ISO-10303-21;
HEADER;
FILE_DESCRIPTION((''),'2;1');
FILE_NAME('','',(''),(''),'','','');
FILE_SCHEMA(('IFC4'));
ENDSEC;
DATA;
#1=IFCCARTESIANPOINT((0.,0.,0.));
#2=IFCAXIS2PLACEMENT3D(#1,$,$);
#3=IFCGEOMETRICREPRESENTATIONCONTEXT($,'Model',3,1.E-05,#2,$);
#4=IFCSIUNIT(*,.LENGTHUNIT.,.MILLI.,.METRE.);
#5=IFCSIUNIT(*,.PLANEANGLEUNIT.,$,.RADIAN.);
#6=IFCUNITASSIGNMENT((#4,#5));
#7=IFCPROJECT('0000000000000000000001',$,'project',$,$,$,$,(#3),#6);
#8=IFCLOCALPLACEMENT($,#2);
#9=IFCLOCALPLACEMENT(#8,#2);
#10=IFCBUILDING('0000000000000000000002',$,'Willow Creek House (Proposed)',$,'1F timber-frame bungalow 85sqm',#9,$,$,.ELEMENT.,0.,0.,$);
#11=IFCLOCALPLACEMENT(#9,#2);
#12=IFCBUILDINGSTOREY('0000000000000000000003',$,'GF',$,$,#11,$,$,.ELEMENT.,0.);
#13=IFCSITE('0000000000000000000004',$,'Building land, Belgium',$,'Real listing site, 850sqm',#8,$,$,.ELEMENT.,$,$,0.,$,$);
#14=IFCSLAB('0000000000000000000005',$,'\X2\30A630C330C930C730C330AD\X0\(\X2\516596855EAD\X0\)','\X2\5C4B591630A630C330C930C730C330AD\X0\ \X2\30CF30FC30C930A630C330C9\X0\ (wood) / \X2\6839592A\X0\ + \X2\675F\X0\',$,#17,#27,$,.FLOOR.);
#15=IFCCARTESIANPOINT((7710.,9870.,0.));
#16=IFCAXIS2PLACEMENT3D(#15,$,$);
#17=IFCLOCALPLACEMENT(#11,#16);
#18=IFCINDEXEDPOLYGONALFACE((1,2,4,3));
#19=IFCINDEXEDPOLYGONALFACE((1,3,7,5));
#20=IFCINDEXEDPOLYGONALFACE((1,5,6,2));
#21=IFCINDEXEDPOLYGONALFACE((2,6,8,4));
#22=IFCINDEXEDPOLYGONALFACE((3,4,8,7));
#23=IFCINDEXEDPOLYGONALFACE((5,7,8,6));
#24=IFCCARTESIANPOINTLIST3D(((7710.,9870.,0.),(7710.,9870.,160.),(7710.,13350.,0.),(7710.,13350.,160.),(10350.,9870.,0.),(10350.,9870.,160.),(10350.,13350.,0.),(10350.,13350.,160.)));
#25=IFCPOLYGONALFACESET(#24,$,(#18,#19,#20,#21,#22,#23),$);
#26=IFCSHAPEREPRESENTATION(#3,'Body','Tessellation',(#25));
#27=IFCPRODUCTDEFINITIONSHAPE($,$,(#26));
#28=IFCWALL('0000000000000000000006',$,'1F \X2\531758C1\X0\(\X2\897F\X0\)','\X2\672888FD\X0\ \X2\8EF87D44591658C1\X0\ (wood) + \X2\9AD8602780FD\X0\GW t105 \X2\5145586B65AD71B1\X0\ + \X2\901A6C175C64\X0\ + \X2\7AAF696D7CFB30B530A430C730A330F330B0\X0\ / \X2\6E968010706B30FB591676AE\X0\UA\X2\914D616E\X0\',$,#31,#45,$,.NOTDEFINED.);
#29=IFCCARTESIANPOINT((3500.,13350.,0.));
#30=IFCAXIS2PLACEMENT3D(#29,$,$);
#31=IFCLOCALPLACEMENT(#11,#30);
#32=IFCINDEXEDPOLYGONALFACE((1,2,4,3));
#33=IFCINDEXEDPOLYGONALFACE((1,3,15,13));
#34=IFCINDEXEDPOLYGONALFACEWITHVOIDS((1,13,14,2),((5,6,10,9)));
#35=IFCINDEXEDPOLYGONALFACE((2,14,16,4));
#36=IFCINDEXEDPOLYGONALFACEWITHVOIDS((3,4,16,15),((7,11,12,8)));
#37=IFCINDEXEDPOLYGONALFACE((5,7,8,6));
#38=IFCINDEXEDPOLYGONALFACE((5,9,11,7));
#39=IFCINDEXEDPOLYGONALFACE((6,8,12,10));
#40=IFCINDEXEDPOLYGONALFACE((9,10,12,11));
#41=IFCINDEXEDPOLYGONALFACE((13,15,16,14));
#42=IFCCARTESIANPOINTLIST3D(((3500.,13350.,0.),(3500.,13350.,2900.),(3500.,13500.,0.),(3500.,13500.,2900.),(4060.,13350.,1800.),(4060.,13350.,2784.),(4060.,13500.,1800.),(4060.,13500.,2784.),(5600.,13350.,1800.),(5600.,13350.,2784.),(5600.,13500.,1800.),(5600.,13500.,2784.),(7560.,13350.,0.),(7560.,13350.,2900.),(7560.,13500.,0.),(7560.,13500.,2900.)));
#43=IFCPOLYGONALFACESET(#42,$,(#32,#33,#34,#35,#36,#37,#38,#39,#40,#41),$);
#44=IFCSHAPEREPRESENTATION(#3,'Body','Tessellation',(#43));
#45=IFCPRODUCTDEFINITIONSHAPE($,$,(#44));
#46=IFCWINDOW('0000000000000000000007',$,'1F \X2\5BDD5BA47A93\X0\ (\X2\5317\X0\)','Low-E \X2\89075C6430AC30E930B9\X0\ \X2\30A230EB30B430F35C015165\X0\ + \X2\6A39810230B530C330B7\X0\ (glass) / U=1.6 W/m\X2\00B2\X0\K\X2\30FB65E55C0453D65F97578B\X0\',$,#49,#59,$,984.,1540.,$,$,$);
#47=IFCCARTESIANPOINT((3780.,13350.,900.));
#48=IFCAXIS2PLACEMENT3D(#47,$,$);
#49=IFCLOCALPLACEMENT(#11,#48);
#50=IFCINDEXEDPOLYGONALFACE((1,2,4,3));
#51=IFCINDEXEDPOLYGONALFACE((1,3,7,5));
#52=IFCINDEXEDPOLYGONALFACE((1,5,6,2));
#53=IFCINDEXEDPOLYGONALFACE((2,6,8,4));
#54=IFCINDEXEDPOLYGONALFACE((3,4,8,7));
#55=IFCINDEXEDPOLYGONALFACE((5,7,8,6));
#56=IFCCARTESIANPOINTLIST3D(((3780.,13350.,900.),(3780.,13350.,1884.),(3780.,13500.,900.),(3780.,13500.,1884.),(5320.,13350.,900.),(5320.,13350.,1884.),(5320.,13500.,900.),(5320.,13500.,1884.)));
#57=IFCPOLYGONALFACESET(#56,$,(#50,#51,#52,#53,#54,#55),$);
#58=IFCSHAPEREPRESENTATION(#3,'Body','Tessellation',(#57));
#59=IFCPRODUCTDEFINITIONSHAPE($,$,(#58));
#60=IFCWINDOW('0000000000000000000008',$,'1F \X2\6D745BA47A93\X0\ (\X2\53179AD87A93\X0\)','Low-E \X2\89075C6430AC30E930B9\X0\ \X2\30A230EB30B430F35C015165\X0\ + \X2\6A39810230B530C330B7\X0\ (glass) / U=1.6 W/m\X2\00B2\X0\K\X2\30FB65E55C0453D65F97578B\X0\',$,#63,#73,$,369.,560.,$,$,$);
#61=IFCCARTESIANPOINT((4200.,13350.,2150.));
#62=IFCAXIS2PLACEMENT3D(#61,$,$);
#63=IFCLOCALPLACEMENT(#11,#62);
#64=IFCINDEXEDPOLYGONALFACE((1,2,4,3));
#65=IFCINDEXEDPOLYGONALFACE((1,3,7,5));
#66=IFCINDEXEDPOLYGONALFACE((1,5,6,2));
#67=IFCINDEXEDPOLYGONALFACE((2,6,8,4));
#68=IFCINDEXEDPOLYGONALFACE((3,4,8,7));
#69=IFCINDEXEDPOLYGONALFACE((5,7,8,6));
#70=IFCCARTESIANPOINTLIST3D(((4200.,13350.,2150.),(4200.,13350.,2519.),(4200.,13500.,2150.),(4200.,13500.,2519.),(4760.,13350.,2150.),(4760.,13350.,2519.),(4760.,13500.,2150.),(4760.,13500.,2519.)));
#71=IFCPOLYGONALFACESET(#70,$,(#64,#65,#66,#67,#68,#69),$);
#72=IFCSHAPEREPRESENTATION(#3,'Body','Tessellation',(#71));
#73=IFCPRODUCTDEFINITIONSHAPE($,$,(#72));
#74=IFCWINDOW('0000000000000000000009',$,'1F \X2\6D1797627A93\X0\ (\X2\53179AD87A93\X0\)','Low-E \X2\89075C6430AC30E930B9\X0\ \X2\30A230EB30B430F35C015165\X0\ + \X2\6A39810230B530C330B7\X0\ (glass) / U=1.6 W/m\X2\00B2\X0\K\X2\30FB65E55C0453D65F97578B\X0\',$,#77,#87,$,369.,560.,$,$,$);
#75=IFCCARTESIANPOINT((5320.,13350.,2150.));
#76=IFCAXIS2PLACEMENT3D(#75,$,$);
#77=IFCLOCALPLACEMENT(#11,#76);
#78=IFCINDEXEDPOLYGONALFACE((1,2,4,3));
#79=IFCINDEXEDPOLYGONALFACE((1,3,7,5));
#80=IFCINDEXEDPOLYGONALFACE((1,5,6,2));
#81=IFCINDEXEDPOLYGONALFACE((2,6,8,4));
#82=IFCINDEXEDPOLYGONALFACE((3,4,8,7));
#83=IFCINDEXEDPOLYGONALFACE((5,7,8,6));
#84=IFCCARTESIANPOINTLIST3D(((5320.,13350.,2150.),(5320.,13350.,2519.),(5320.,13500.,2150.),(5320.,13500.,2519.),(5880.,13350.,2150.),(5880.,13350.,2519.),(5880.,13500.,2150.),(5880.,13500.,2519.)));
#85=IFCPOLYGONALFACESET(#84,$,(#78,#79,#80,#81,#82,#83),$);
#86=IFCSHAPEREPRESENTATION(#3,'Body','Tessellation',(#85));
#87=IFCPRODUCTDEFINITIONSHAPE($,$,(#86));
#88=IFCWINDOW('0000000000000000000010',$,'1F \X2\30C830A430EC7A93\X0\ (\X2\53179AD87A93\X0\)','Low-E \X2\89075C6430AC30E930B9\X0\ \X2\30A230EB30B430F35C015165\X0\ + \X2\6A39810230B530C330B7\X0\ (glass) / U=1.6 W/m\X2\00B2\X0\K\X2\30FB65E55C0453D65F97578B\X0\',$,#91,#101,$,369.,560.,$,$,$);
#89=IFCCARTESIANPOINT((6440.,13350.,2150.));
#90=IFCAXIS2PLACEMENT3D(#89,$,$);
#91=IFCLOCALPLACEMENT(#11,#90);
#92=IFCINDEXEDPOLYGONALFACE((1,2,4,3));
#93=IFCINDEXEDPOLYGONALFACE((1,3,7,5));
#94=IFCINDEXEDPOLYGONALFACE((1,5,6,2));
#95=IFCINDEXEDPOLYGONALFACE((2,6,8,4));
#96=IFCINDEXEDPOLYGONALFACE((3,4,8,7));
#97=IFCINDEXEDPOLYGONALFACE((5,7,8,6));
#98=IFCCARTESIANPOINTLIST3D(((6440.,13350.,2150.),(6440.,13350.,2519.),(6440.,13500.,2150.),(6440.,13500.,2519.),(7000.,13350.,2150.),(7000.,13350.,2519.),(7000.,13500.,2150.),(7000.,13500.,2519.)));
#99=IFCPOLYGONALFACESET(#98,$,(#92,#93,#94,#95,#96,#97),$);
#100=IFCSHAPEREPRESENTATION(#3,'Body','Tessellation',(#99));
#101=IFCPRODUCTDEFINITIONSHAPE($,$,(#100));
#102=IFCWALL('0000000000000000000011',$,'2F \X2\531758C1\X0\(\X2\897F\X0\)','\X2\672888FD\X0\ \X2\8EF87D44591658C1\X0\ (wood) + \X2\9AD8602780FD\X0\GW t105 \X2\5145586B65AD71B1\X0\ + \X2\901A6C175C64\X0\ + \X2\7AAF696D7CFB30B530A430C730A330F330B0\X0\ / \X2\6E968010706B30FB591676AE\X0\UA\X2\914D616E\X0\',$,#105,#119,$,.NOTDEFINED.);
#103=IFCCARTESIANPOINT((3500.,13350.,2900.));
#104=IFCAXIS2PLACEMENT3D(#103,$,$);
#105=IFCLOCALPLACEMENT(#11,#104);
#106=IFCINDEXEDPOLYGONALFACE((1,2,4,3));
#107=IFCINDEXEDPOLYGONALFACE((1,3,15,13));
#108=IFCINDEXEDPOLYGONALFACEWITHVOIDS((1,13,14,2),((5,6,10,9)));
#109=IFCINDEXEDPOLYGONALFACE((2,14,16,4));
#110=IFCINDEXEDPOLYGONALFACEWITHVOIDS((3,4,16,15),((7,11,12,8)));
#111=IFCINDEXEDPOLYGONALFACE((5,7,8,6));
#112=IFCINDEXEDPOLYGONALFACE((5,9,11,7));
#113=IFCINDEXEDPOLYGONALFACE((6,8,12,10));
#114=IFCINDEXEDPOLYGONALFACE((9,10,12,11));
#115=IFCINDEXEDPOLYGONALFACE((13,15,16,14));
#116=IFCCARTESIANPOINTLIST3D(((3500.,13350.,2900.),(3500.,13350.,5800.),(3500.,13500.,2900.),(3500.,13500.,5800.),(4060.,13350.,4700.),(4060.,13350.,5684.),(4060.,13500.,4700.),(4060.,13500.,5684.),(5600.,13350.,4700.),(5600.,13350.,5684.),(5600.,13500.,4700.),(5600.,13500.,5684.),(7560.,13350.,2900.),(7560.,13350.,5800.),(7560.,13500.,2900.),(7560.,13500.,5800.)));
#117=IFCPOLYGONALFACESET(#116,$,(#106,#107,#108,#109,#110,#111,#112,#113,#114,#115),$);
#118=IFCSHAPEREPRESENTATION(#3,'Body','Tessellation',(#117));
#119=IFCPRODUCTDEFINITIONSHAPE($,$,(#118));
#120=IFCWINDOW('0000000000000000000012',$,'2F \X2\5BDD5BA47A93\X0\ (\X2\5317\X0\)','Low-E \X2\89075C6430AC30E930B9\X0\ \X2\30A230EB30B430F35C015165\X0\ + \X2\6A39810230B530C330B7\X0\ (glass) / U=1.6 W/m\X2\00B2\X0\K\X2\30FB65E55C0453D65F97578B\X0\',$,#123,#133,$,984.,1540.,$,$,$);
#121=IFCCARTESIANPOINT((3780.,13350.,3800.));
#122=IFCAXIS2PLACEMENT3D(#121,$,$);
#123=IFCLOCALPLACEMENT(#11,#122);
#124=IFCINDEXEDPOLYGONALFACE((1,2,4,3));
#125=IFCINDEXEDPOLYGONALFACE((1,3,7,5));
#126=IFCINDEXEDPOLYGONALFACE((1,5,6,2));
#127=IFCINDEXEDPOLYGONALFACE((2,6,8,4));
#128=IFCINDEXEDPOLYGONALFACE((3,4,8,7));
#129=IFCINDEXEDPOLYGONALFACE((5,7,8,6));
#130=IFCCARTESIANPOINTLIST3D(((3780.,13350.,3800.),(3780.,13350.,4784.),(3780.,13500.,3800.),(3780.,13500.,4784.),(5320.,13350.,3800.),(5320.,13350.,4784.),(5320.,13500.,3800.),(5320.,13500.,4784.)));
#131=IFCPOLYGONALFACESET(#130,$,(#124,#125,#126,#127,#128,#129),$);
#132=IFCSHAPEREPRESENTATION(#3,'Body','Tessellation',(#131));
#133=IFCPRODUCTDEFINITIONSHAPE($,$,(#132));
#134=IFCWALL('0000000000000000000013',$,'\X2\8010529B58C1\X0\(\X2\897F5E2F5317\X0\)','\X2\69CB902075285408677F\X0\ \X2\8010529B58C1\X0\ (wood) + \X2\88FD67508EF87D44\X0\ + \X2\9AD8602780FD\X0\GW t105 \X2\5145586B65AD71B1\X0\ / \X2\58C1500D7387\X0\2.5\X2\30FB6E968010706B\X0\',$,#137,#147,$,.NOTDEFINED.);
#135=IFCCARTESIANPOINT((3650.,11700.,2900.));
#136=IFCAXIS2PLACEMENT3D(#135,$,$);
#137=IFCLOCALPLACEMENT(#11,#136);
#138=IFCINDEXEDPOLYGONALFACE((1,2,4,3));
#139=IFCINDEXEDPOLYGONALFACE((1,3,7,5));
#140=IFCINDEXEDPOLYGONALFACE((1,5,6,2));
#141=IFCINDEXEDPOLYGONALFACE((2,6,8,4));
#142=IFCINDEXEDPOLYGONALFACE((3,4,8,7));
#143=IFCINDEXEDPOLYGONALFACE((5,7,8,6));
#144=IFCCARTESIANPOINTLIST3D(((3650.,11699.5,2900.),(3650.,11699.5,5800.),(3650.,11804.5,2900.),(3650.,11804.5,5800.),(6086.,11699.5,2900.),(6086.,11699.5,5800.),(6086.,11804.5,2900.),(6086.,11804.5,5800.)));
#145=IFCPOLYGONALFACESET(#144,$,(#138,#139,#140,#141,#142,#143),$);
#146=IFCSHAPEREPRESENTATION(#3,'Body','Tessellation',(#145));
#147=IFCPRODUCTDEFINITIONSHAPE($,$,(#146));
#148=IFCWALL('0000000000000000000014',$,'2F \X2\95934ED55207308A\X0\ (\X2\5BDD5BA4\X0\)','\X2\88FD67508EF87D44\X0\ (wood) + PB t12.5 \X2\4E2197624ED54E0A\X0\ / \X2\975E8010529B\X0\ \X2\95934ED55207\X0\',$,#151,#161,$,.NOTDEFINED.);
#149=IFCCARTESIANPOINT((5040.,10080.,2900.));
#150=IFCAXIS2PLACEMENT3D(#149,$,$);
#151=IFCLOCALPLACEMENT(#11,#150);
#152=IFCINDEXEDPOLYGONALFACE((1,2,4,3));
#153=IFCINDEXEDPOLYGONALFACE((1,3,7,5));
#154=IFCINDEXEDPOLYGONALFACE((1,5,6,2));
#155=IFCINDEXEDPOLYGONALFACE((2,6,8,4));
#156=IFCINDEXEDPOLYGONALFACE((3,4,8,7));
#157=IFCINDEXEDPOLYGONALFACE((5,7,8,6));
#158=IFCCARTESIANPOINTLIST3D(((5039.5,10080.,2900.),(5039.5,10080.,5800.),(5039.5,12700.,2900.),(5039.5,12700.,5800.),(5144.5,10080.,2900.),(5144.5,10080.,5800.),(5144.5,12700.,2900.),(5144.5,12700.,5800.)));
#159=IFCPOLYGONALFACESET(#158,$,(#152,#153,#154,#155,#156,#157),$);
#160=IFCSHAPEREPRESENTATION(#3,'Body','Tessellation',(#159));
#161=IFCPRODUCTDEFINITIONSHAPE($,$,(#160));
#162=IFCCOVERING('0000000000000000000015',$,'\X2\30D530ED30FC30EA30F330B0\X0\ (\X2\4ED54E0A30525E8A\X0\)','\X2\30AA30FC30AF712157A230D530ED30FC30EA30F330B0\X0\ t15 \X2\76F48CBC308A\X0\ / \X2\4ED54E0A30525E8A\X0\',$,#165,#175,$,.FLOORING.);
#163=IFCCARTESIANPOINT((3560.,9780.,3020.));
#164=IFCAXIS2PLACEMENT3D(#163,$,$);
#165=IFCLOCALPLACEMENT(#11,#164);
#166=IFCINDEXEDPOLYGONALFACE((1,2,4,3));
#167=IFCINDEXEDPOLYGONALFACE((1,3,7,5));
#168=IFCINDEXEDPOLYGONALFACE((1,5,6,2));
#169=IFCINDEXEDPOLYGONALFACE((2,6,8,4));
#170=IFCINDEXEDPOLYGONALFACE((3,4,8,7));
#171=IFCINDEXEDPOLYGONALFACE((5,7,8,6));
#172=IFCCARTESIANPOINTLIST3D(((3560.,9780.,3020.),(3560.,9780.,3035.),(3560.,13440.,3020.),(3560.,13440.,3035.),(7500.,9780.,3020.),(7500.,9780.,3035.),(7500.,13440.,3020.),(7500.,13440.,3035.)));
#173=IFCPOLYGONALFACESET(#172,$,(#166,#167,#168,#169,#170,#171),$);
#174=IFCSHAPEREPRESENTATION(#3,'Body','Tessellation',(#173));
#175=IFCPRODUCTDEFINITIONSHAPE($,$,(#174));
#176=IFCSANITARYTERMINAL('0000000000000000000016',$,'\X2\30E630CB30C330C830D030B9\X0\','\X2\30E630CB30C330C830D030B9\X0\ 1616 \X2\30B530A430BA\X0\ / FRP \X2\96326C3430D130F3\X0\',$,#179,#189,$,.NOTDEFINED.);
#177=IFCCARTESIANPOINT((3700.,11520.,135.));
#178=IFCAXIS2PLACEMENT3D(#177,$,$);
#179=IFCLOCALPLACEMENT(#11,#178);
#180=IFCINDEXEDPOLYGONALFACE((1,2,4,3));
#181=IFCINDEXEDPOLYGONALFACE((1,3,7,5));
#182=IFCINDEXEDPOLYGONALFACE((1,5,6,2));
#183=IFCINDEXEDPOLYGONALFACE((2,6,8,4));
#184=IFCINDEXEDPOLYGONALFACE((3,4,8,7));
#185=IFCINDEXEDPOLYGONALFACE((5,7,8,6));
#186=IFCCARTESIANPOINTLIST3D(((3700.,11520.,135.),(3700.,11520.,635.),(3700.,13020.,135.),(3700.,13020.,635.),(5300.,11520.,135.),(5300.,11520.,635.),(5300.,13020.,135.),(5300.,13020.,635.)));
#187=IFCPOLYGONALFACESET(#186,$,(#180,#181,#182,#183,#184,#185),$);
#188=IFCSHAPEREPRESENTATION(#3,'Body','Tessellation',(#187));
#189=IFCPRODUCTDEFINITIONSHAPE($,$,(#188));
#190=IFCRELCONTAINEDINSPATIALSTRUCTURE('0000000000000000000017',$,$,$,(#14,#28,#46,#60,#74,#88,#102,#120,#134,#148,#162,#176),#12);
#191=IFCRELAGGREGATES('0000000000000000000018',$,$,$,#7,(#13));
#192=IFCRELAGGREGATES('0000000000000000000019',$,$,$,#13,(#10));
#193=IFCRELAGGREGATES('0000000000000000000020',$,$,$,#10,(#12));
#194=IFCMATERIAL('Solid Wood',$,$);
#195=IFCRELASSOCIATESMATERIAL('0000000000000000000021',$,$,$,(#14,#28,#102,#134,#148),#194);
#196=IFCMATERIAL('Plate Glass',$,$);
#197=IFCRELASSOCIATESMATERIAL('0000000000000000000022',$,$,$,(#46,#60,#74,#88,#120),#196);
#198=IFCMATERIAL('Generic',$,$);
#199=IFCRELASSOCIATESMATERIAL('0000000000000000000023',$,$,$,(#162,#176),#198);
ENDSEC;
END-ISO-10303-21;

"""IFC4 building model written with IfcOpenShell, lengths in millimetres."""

from ifc_helpers import new_model, si_unit, frame, frame_2d, origin, place, context, project, spatial, rectangle, extrude, material, element, fill, save


model = new_model("IFC4")

# Units and contexts
model_context = context("Model", 3, precision=1e-05, world=origin())
ifc_project = project(units=[si_unit("LENGTHUNIT", "METRE", prefix="MILLI"), si_unit("PLANEANGLEUNIT", "RADIAN")], contexts=[model_context])

# Site, building, storey
site_placement = place(None, origin())
site = spatial("IfcSite", under=ifc_project, at=site_placement, Name="Building land, Belgium", ObjectType="Real listing site, 850sqm", CompositionType="ELEMENT", RefElevation=0.0)
building_placement = place(site_placement, origin())
building = spatial("IfcBuilding", under=site, at=building_placement, Name="Willow Creek House (Proposed)", ObjectType="1F timber-frame bungalow 85sqm", CompositionType="ELEMENT", ElevationOfRefHeight=0.0, ElevationOfTerrain=0.0)
storey_placement = place(building_placement, origin())
storey = spatial("IfcBuildingStorey", under=building, at=storey_placement, Name="GF", CompositionType="ELEMENT", Elevation=0.0)

# Slab
ifc_material_1 = material(Name="Solid Wood")
slab_placement = place(storey_placement, frame((7710.0, 9870.0, 0.0)))
element("IfcSlab", 1, at=slab_placement, inside=storey, material=ifc_material_1, Name="ウッドデッキ(入隅庭)", Description="屋外ウッドデッキ ハードウッド (wood) / 根太 + 束", PredefinedType="FLOOR", context=model_context, shape_type="SweptSolid", body=[
    extrude(rectangle(XDim=2640.0, YDim=3480.0, at=frame_2d((1320.0, 1740.0))), frame((7710.0, 9870.0, 0.0)), (0.0, 0.0, 1.0), 160.0),
])

# Wall, openings, windows
wall_1_placement = place(storey_placement, frame((3500.0, 13350.0, 0.0)))
wall_1 = element("IfcWall", 2, at=wall_1_placement, inside=storey, material=ifc_material_1, Name="1F 北壁(西)", Description="木製 軸組外壁 (wood) + 高性能GW t105 充填断熱 + 通気層 + 窯業系サイディング / 準耐火・外皮UA配慮", PredefinedType="NOTDEFINED", context=model_context, shape_type="SweptSolid", body=[
    extrude(rectangle(XDim=4060.0, YDim=150.0, at=frame_2d((2030.0, 75.0))), frame((3500.0, 13350.0, 0.0)), (0.0, 0.0, 1.0), 2900.0),
])
opening_1_placement = place(storey_placement, frame((3780.0, 13350.0, 900.0)))
opening_1 = element("IfcOpeningElement", 3, at=opening_1_placement, cuts=wall_1, PredefinedType="NOTDEFINED", context=model_context, shape_type="SweptSolid", body=[
    extrude(rectangle(XDim=1540.0, YDim=150.0, at=frame_2d((770.0, 75.0))), frame((3780.0, 13350.0, 900.0)), (0.0, 0.0, 1.0), 984.0),
])
opening_2_placement = place(storey_placement, frame((4200.0, 13350.0, 2150.0)))
opening_2 = element("IfcOpeningElement", 4, at=opening_2_placement, cuts=wall_1, PredefinedType="NOTDEFINED", context=model_context, shape_type="SweptSolid", body=[
    extrude(rectangle(XDim=560.0, YDim=150.0, at=frame_2d((280.0, 75.0))), frame((4200.0, 13350.0, 2150.0)), (0.0, 0.0, 1.0), 369.0),
])
opening_3_placement = place(storey_placement, frame((5320.0, 13350.0, 2150.0)))
opening_3 = element("IfcOpeningElement", 5, at=opening_3_placement, cuts=wall_1, PredefinedType="NOTDEFINED", context=model_context, shape_type="SweptSolid", body=[
    extrude(rectangle(XDim=560.0, YDim=150.0, at=frame_2d((280.0, 75.0))), frame((5320.0, 13350.0, 2150.0)), (0.0, 0.0, 1.0), 369.0),
])
opening_4_placement = place(storey_placement, frame((6440.0, 13350.0, 2150.0)))
opening_4 = element("IfcOpeningElement", 6, at=opening_4_placement, cuts=wall_1, PredefinedType="NOTDEFINED", context=model_context, shape_type="SweptSolid", body=[
    extrude(rectangle(XDim=560.0, YDim=150.0, at=frame_2d((280.0, 75.0))), frame((6440.0, 13350.0, 2150.0)), (0.0, 0.0, 1.0), 369.0),
])
ifc_material_2 = material(Name="Plate Glass")
window_1_placement = place(storey_placement, frame((3780.0, 13350.0, 900.0)))
window_1 = element("IfcWindow", 7, at=window_1_placement, inside=storey, material=ifc_material_2, Name="1F 寝室窓 (北)", Description="Low-E 複層ガラス アルゴン封入 + 樹脂サッシ (glass) / U=1.6 W/m²K・日射取得型", OverallHeight=984.0, OverallWidth=1540.0, context=model_context, shape_type="SweptSolid", body=[
    extrude(rectangle(XDim=1540.0, YDim=150.0, at=frame_2d((770.0, 75.0))), frame((3780.0, 13350.0, 900.0)), (0.0, 0.0, 1.0), 984.0),
])
fill(opening_1, window_1)
window_2_placement = place(storey_placement, frame((4200.0, 13350.0, 2150.0)))
window_2 = element("IfcWindow", 8, at=window_2_placement, inside=storey, material=ifc_material_2, Name="1F 浴室窓 (北高窓)", Description="Low-E 複層ガラス アルゴン封入 + 樹脂サッシ (glass) / U=1.6 W/m²K・日射取得型", OverallHeight=369.0, OverallWidth=560.0, context=model_context, shape_type="SweptSolid", body=[
    extrude(rectangle(XDim=560.0, YDim=150.0, at=frame_2d((280.0, 75.0))), frame((4200.0, 13350.0, 2150.0)), (0.0, 0.0, 1.0), 369.0),
])
fill(opening_2, window_2)
window_3_placement = place(storey_placement, frame((5320.0, 13350.0, 2150.0)))
window_3 = element("IfcWindow", 9, at=window_3_placement, inside=storey, material=ifc_material_2, Name="1F 洗面窓 (北高窓)", Description="Low-E 複層ガラス アルゴン封入 + 樹脂サッシ (glass) / U=1.6 W/m²K・日射取得型", OverallHeight=369.0, OverallWidth=560.0, context=model_context, shape_type="SweptSolid", body=[
    extrude(rectangle(XDim=560.0, YDim=150.0, at=frame_2d((280.0, 75.0))), frame((5320.0, 13350.0, 2150.0)), (0.0, 0.0, 1.0), 369.0),
])
fill(opening_3, window_3)
window_4_placement = place(storey_placement, frame((6440.0, 13350.0, 2150.0)))
window_4 = element("IfcWindow", 10, at=window_4_placement, inside=storey, material=ifc_material_2, Name="1F トイレ窓 (北高窓)", Description="Low-E 複層ガラス アルゴン封入 + 樹脂サッシ (glass) / U=1.6 W/m²K・日射取得型", OverallHeight=369.0, OverallWidth=560.0, context=model_context, shape_type="SweptSolid", body=[
    extrude(rectangle(XDim=560.0, YDim=150.0, at=frame_2d((280.0, 75.0))), frame((6440.0, 13350.0, 2150.0)), (0.0, 0.0, 1.0), 369.0),
])
fill(opening_4, window_4)

# Wall, opening, window
wall_2_placement = place(storey_placement, frame((3500.0, 13350.0, 2900.0)))
wall_2 = element("IfcWall", 11, at=wall_2_placement, inside=storey, material=ifc_material_1, Name="2F 北壁(西)", Description="木製 軸組外壁 (wood) + 高性能GW t105 充填断熱 + 通気層 + 窯業系サイディング / 準耐火・外皮UA配慮", PredefinedType="NOTDEFINED", context=model_context, shape_type="SweptSolid", body=[
    extrude(rectangle(XDim=4060.0, YDim=150.0, at=frame_2d((2030.0, 75.0))), frame((3500.0, 13350.0, 2900.0)), (0.0, 0.0, 1.0), 2900.0),
])
opening_5_placement = place(storey_placement, frame((3780.0, 13350.0, 3800.0)))
opening_5 = element("IfcOpeningElement", 12, at=opening_5_placement, cuts=wall_2, PredefinedType="NOTDEFINED", context=model_context, shape_type="SweptSolid", body=[
    extrude(rectangle(XDim=1540.0, YDim=150.0, at=frame_2d((770.0, 75.0))), frame((3780.0, 13350.0, 3800.0)), (0.0, 0.0, 1.0), 984.0),
])
window_5_placement = place(storey_placement, frame((3780.0, 13350.0, 3800.0)))
window_5 = element("IfcWindow", 13, at=window_5_placement, inside=storey, material=ifc_material_2, Name="2F 寝室窓 (北)", Description="Low-E 複層ガラス アルゴン封入 + 樹脂サッシ (glass) / U=1.6 W/m²K・日射取得型", OverallHeight=984.0, OverallWidth=1540.0, context=model_context, shape_type="SweptSolid", body=[
    extrude(rectangle(XDim=1540.0, YDim=150.0, at=frame_2d((770.0, 75.0))), frame((3780.0, 13350.0, 3800.0)), (0.0, 0.0, 1.0), 984.0),
])
fill(opening_5, window_5)

# Walls
wall_3_placement = place(storey_placement, frame((3650.0, 11700.0, 2900.0)))
element("IfcWall", 14, at=wall_3_placement, inside=storey, material=ifc_material_1, Name="耐力壁(西帯北)", Description="構造用合板 耐力壁 (wood) + 製材軸組 + 高性能GW t105 充填断熱 / 壁倍率2.5・準耐火", PredefinedType="NOTDEFINED", context=model_context, shape_type="SweptSolid", body=[
    extrude(rectangle(XDim=2436.0, YDim=105.0, at=frame_2d((1218.0, 52.0))), frame((3650.0, 11700.0, 2900.0)), (0.0, 0.0, 1.0), 2900.0),
])
wall_4_placement = place(storey_placement, frame((5040.0, 10080.0, 2900.0)))
element("IfcWall", 15, at=wall_4_placement, inside=storey, material=ifc_material_1, Name="2F 間仕切り (寝室)", Description="製材軸組 (wood) + PB t12.5 両面仕上 / 非耐力 間仕切", PredefinedType="NOTDEFINED", context=model_context, shape_type="SweptSolid", body=[
    extrude(rectangle(XDim=105.0, YDim=2620.0, at=frame_2d((52.0, 1310.0))), frame((5040.0, 10080.0, 2900.0)), (0.0, 0.0, 1.0), 2900.0),
])

# Covering
ifc_material_3 = material(Name="Generic")
covering_placement = place(storey_placement, frame((3560.0, 9780.0, 3020.0)))
element("IfcCovering", 16, at=covering_placement, inside=storey, material=ifc_material_3, Name="フローリング (仕上げ床)", Description="オーク無垢フローリング t15 直貼り / 仕上げ床", PredefinedType="FLOORING", context=model_context, shape_type="SweptSolid", body=[
    extrude(rectangle(XDim=3940.0, YDim=3660.0, at=frame_2d((1970.0, 1830.0))), frame((3560.0, 9780.0, 3020.0)), (0.0, 0.0, 1.0), 15.0),
])

# Sanitary terminal
sanitary_terminal_1_placement = place(storey_placement, frame((3700.0, 11520.0, 135.0)))
element("IfcSanitaryTerminal", 17, at=sanitary_terminal_1_placement, inside=storey, material=ifc_material_3, Name="ユニットバス", Description="ユニットバス 1616 サイズ / FRP 防水パン", PredefinedType="NOTDEFINED", context=model_context, shape_type="SweptSolid", body=[
    extrude(rectangle(XDim=1600.0, YDim=1500.0, at=frame_2d((800.0, 750.0))), frame((3700.0, 11520.0, 135.0)), (0.0, 0.0, 1.0), 500.0),
])

save(model, "model.ifc")
